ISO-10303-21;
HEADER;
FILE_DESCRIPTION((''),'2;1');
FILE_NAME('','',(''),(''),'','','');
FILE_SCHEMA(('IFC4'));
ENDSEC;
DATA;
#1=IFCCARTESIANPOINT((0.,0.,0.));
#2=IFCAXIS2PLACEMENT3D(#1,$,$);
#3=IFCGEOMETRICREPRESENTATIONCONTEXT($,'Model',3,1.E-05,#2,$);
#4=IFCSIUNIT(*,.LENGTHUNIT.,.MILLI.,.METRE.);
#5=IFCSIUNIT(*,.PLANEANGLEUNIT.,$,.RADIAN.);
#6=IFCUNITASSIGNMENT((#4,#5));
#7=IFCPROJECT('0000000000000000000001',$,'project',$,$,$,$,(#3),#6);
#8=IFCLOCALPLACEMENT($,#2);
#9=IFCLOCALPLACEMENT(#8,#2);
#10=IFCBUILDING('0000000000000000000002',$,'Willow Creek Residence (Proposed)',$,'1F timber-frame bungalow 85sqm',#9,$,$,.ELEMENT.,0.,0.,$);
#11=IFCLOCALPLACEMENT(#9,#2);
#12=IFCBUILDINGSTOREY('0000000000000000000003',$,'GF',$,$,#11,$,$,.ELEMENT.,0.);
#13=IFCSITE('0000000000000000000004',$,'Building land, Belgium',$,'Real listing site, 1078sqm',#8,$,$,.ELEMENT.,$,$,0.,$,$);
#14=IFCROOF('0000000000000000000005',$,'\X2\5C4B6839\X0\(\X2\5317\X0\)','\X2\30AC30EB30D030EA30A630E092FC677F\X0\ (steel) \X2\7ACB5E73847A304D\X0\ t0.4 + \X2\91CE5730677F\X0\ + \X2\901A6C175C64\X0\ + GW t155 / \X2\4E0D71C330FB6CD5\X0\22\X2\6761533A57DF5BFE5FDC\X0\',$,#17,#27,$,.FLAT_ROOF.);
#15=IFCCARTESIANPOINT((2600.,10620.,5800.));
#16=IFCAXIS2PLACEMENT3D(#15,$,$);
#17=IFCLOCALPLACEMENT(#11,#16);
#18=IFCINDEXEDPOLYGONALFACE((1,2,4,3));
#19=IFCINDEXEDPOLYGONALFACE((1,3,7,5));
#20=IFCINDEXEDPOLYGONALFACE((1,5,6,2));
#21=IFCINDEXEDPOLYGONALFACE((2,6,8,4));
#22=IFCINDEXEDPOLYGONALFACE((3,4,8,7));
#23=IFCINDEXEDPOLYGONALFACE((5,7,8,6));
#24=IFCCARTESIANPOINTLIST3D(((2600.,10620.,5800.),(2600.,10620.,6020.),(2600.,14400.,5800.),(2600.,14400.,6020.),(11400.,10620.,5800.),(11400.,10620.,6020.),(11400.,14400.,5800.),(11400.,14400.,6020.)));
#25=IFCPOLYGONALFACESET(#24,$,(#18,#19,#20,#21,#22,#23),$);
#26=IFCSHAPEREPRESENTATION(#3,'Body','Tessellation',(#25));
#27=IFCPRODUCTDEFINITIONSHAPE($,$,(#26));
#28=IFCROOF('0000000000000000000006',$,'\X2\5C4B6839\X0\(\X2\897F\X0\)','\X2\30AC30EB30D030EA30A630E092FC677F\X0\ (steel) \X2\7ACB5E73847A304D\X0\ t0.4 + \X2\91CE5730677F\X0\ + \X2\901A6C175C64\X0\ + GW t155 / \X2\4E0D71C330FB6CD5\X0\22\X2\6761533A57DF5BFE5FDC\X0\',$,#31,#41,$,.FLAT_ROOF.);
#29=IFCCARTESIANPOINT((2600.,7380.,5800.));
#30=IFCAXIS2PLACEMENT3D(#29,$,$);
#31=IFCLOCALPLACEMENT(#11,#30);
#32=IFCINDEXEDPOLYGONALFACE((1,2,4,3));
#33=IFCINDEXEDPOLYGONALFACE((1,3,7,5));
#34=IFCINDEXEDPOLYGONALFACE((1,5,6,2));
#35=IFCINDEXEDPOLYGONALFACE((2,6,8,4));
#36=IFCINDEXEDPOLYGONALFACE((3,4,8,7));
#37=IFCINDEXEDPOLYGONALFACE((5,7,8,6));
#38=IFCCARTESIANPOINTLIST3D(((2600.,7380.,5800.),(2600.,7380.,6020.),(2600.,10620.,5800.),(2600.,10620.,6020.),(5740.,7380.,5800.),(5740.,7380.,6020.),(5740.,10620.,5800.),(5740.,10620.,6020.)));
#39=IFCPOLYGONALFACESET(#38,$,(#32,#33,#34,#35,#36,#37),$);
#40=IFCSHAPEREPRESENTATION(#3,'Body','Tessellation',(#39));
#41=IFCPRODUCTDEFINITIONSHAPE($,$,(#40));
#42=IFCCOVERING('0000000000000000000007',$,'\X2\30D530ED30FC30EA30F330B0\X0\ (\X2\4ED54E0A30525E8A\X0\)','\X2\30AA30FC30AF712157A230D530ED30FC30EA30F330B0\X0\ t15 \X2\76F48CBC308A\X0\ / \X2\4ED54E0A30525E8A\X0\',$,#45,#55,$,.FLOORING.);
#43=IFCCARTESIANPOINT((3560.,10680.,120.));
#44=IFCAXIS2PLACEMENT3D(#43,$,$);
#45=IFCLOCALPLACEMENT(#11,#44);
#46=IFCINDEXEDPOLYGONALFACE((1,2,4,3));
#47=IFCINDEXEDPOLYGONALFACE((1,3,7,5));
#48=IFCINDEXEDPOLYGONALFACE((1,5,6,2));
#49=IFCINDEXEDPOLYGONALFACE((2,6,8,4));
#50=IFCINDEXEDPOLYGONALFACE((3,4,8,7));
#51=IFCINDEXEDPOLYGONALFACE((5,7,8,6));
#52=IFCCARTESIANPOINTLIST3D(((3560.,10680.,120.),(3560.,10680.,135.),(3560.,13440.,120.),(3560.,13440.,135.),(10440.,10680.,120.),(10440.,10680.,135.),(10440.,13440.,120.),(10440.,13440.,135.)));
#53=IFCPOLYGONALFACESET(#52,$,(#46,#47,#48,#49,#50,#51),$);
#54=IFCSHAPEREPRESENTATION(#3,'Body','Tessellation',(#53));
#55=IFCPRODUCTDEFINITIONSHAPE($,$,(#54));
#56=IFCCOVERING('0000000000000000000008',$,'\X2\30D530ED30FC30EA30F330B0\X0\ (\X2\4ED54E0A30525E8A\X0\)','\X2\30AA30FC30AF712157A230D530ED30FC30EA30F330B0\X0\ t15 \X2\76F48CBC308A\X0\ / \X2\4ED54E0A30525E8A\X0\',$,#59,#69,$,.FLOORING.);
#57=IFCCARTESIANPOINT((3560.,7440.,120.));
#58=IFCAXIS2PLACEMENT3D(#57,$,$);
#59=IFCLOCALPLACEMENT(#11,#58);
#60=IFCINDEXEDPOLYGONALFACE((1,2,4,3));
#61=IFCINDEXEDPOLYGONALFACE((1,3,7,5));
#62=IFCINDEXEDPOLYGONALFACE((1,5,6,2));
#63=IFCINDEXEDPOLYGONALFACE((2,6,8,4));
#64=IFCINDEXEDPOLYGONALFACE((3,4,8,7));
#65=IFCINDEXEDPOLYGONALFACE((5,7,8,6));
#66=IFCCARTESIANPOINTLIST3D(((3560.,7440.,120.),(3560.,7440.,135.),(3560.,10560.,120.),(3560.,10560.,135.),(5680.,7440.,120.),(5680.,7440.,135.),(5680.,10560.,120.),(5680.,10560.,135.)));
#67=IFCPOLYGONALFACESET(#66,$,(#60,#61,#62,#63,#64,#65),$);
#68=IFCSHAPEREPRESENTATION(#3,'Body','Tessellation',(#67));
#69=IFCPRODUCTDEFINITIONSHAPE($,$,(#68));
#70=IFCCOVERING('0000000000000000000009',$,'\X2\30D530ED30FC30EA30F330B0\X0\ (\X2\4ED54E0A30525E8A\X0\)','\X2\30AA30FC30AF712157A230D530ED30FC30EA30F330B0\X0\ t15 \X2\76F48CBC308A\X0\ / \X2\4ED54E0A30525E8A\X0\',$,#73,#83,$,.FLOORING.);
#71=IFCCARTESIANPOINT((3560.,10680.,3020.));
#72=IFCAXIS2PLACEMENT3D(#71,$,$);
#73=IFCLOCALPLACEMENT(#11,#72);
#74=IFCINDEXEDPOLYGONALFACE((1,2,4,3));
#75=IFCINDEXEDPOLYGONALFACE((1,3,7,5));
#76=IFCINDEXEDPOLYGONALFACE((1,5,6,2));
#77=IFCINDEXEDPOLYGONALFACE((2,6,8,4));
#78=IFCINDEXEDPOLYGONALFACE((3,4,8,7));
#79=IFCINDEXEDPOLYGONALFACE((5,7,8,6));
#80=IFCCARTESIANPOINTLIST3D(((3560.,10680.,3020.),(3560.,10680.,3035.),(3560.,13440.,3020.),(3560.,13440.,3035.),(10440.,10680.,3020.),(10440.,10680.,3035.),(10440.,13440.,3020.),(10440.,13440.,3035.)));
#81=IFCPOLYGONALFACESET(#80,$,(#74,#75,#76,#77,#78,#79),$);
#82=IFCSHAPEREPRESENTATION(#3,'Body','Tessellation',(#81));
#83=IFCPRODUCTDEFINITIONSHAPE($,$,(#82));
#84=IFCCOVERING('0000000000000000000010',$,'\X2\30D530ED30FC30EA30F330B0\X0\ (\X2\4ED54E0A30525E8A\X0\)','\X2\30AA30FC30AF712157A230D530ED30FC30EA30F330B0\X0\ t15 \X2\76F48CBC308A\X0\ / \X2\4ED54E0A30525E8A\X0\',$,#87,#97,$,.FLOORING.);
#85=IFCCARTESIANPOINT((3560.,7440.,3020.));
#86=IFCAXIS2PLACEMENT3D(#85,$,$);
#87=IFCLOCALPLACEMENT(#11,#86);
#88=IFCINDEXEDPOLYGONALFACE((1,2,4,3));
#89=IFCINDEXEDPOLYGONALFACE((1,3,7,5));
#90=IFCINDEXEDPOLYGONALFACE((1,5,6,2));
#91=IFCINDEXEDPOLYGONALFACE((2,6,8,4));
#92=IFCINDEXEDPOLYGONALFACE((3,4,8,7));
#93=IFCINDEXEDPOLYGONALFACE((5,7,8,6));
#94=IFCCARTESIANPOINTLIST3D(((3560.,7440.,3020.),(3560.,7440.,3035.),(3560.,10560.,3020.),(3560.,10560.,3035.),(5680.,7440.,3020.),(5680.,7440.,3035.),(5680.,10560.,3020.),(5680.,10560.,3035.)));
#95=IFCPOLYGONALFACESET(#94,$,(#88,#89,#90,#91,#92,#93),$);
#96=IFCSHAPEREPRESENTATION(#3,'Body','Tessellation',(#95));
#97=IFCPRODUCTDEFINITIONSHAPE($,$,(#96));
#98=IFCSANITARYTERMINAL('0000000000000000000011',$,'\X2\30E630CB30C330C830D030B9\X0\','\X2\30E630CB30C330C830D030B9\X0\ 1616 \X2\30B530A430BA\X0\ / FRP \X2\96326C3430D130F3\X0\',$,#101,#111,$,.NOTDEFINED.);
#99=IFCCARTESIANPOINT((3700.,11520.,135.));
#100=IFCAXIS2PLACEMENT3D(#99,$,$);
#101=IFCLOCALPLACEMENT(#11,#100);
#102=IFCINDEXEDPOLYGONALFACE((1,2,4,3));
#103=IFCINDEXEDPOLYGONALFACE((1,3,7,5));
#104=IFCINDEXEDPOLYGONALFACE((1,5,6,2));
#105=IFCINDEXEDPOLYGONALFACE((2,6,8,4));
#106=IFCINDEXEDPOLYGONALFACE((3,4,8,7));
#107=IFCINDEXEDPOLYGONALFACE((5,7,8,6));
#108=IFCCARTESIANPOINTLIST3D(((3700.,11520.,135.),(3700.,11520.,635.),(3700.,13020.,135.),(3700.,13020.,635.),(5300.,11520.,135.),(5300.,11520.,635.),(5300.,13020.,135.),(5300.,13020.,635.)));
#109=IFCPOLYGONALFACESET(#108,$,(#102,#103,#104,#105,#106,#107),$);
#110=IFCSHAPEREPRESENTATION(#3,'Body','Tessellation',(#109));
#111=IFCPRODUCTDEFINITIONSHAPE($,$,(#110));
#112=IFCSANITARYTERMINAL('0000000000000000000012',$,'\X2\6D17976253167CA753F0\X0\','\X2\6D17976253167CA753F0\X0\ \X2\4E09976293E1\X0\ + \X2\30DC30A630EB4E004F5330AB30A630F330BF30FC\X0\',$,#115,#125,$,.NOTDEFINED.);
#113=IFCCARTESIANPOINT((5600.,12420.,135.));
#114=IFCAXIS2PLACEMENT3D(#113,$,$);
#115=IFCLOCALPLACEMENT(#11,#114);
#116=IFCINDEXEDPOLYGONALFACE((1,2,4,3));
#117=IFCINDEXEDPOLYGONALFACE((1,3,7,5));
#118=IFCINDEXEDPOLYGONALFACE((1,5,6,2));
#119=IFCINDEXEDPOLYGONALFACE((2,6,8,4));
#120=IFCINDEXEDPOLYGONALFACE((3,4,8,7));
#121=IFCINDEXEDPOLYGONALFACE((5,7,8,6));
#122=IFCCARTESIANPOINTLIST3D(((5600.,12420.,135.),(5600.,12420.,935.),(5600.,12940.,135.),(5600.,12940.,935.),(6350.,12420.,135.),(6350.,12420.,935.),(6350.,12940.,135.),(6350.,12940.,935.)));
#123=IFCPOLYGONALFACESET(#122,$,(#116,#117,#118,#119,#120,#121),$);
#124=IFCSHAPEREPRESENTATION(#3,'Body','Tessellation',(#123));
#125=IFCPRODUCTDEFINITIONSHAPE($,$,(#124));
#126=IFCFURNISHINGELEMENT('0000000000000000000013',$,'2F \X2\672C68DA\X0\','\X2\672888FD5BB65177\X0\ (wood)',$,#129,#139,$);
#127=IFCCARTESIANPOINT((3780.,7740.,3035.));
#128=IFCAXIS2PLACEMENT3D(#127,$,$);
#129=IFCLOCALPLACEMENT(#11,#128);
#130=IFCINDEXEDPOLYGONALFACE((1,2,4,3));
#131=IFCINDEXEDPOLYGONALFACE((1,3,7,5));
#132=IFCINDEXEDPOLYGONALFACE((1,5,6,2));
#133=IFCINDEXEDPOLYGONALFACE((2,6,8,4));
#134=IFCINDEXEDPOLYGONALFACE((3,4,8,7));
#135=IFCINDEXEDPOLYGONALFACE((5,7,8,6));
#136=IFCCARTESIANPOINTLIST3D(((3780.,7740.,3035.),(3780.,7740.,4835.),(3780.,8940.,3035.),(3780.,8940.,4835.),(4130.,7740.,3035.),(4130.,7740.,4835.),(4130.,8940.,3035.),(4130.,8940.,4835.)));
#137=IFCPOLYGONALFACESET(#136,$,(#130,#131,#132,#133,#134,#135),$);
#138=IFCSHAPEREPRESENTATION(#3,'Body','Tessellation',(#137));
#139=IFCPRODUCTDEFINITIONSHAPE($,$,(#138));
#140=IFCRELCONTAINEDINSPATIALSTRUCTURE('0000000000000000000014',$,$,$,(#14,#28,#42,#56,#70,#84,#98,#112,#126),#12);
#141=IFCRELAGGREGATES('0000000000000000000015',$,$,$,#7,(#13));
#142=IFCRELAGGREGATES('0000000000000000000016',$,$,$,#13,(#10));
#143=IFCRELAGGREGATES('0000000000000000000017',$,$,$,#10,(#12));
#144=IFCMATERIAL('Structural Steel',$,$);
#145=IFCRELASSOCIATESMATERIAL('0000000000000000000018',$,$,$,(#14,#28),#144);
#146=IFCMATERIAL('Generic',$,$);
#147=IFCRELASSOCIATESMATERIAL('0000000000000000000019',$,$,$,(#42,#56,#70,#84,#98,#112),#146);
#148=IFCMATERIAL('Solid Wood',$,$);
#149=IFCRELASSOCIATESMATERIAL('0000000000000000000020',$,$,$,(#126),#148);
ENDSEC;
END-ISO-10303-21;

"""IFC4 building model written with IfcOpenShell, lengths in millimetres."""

from ifc_helpers import new_model, si_unit, frame, frame_2d, origin, place, context, project, spatial, rectangle, extrude, material, element, save


model = new_model("IFC4")

# Units and contexts
model_context = context("Model", 3, precision=1e-05, world=origin())
ifc_project = project(units=[si_unit("LENGTHUNIT", "METRE", prefix="MILLI"), si_unit("PLANEANGLEUNIT", "RADIAN")], contexts=[model_context])

# Site, building, storey
site_placement = place(None, origin())
site = spatial("IfcSite", under=ifc_project, at=site_placement, Name="Building land, Belgium", ObjectType="Real listing site, 1078sqm", CompositionType="ELEMENT", RefElevation=0.0)
building_placement = place(site_placement, origin())
building = spatial("IfcBuilding", under=site, at=building_placement, Name="Willow Creek Residence (Proposed)", ObjectType="1F timber-frame bungalow 85sqm", CompositionType="ELEMENT", ElevationOfRefHeight=0.0, ElevationOfTerrain=0.0)
storey_placement = place(building_placement, origin())
storey = spatial("IfcBuildingStorey", under=building, at=storey_placement, Name="GF", CompositionType="ELEMENT", Elevation=0.0)

# Shared definitions
ifc_material_1 = material(Name="Solid Wood")

# Roofs
ifc_material_2 = material(Name="Structural Steel")
for number, where, name in (
    (1, (2600.0, 10620.0, 5800.0), "屋根(北)"),
):
    element("IfcRoof", number, at=place(storey_placement, frame(where)), inside=storey, material=ifc_material_2, Name=name, Description="ガルバリウム鋼板 (steel) 立平葺き t0.4 + 野地板 + 通気層 + GW t155 / 不燃・法22条区域対応", PredefinedType="FLAT_ROOF", context=model_context, shape_type="SweptSolid", body=[
        extrude(rectangle(XDim=8800.0, YDim=3780.0, at=frame_2d((4400.0, 1890.0))), frame((2600.0, 10620.0, 5800.0)), (0.0, 0.0, 1.0), 220.0),
    ])
roof_placement = place(storey_placement, frame((2600.0, 7380.0, 5800.0)))
element("IfcRoof", 2, at=roof_placement, inside=storey, material=ifc_material_2, Name="屋根(西)", Description="ガルバリウム鋼板 (steel) 立平葺き t0.4 + 野地板 + 通気層 + GW t155 / 不燃・法22条区域対応", PredefinedType="FLAT_ROOF", context=model_context, shape_type="SweptSolid", body=[
    extrude(rectangle(XDim=3140.0, YDim=3240.0, at=frame_2d((1570.0, 1620.0))), frame((2600.0, 7380.0, 5800.0)), (0.0, 0.0, 1.0), 220.0),
])

# Coverings
ifc_material_3 = material(Name="Generic")
covering_1_placement = place(storey_placement, frame((3560.0, 10680.0, 120.0)))
element("IfcCovering", 3, at=covering_1_placement, inside=storey, material=ifc_material_3, Name="フローリング (仕上げ床)", Description="オーク無垢フローリング t15 直貼り / 仕上げ床", PredefinedType="FLOORING", context=model_context, shape_type="SweptSolid", body=[
    extrude(rectangle(XDim=6880.0, YDim=2760.0, at=frame_2d((3440.0, 1380.0))), frame((3560.0, 10680.0, 120.0)), (0.0, 0.0, 1.0), 15.0),
])
covering_2_placement = place(storey_placement, frame((3560.0, 7440.0, 120.0)))
element("IfcCovering", 4, at=covering_2_placement, inside=storey, material=ifc_material_3, Name="フローリング (仕上げ床)", Description="オーク無垢フローリング t15 直貼り / 仕上げ床", PredefinedType="FLOORING", context=model_context, shape_type="SweptSolid", body=[
    extrude(rectangle(XDim=2120.0, YDim=3120.0, at=frame_2d((1060.0, 1560.0))), frame((3560.0, 7440.0, 120.0)), (0.0, 0.0, 1.0), 15.0),
])
covering_3_placement = place(storey_placement, frame((3560.0, 10680.0, 3020.0)))
element("IfcCovering", 5, at=covering_3_placement, inside=storey, material=ifc_material_3, Name="フローリング (仕上げ床)", Description="オーク無垢フローリング t15 直貼り / 仕上げ床", PredefinedType="FLOORING", context=model_context, shape_type="SweptSolid", body=[
    extrude(rectangle(XDim=6880.0, YDim=2760.0, at=frame_2d((3440.0, 1380.0))), frame((3560.0, 10680.0, 3020.0)), (0.0, 0.0, 1.0), 15.0),
])
covering_4_placement = place(storey_placement, frame((3560.0, 7440.0, 3020.0)))
element("IfcCovering", 6, at=covering_4_placement, inside=storey, material=ifc_material_3, Name="フローリング (仕上げ床)", Description="オーク無垢フローリング t15 直貼り / 仕上げ床", PredefinedType="FLOORING", context=model_context, shape_type="SweptSolid", body=[
    extrude(rectangle(XDim=2120.0, YDim=3120.0, at=frame_2d((1060.0, 1560.0))), frame((3560.0, 7440.0, 3020.0)), (0.0, 0.0, 1.0), 15.0),
])

# Sanitary terminals
sanitary_terminal_1_placement = place(storey_placement, frame((3700.0, 11520.0, 135.0)))
element("IfcSanitaryTerminal", 7, at=sanitary_terminal_1_placement, inside=storey, material=ifc_material_3, Name="ユニットバス", Description="ユニットバス 1616 サイズ / FRP 防水パン", PredefinedType="NOTDEFINED", context=model_context, shape_type="SweptSolid", body=[
    extrude(rectangle(XDim=1600.0, YDim=1500.0, at=frame_2d((800.0, 750.0))), frame((3700.0, 11520.0, 135.0)), (0.0, 0.0, 1.0), 500.0),
])
sanitary_terminal_2_placement = place(storey_placement, frame((5600.0, 12420.0, 135.0)))
element("IfcSanitaryTerminal", 8, at=sanitary_terminal_2_placement, inside=storey, material=ifc_material_3, Name="洗面化粧台", Description="洗面化粧台 三面鏡 + ボウル一体カウンター", PredefinedType="NOTDEFINED", context=model_context, shape_type="SweptSolid", body=[
    extrude(rectangle(XDim=750.0, YDim=520.0, at=frame_2d((375.0, 260.0))), frame((5600.0, 12420.0, 135.0)), (0.0, 0.0, 1.0), 800.0),
])

# Furnishing element
furnishing_placement = place(storey_placement, frame((3780.0, 7740.0, 3035.0)))
element("IfcFurnishingElement", 9, at=furnishing_placement, inside=storey, material=ifc_material_1, Name="2F 本棚", Description="木製家具 (wood)", context=model_context, shape_type="SweptSolid", body=[
    extrude(rectangle(XDim=350.0, YDim=1200.0, at=frame_2d((175.0, 600.0))), frame((3780.0, 7740.0, 3035.0)), (0.0, 0.0, 1.0), 1800.0),
])

save(model, "model.ifc")
